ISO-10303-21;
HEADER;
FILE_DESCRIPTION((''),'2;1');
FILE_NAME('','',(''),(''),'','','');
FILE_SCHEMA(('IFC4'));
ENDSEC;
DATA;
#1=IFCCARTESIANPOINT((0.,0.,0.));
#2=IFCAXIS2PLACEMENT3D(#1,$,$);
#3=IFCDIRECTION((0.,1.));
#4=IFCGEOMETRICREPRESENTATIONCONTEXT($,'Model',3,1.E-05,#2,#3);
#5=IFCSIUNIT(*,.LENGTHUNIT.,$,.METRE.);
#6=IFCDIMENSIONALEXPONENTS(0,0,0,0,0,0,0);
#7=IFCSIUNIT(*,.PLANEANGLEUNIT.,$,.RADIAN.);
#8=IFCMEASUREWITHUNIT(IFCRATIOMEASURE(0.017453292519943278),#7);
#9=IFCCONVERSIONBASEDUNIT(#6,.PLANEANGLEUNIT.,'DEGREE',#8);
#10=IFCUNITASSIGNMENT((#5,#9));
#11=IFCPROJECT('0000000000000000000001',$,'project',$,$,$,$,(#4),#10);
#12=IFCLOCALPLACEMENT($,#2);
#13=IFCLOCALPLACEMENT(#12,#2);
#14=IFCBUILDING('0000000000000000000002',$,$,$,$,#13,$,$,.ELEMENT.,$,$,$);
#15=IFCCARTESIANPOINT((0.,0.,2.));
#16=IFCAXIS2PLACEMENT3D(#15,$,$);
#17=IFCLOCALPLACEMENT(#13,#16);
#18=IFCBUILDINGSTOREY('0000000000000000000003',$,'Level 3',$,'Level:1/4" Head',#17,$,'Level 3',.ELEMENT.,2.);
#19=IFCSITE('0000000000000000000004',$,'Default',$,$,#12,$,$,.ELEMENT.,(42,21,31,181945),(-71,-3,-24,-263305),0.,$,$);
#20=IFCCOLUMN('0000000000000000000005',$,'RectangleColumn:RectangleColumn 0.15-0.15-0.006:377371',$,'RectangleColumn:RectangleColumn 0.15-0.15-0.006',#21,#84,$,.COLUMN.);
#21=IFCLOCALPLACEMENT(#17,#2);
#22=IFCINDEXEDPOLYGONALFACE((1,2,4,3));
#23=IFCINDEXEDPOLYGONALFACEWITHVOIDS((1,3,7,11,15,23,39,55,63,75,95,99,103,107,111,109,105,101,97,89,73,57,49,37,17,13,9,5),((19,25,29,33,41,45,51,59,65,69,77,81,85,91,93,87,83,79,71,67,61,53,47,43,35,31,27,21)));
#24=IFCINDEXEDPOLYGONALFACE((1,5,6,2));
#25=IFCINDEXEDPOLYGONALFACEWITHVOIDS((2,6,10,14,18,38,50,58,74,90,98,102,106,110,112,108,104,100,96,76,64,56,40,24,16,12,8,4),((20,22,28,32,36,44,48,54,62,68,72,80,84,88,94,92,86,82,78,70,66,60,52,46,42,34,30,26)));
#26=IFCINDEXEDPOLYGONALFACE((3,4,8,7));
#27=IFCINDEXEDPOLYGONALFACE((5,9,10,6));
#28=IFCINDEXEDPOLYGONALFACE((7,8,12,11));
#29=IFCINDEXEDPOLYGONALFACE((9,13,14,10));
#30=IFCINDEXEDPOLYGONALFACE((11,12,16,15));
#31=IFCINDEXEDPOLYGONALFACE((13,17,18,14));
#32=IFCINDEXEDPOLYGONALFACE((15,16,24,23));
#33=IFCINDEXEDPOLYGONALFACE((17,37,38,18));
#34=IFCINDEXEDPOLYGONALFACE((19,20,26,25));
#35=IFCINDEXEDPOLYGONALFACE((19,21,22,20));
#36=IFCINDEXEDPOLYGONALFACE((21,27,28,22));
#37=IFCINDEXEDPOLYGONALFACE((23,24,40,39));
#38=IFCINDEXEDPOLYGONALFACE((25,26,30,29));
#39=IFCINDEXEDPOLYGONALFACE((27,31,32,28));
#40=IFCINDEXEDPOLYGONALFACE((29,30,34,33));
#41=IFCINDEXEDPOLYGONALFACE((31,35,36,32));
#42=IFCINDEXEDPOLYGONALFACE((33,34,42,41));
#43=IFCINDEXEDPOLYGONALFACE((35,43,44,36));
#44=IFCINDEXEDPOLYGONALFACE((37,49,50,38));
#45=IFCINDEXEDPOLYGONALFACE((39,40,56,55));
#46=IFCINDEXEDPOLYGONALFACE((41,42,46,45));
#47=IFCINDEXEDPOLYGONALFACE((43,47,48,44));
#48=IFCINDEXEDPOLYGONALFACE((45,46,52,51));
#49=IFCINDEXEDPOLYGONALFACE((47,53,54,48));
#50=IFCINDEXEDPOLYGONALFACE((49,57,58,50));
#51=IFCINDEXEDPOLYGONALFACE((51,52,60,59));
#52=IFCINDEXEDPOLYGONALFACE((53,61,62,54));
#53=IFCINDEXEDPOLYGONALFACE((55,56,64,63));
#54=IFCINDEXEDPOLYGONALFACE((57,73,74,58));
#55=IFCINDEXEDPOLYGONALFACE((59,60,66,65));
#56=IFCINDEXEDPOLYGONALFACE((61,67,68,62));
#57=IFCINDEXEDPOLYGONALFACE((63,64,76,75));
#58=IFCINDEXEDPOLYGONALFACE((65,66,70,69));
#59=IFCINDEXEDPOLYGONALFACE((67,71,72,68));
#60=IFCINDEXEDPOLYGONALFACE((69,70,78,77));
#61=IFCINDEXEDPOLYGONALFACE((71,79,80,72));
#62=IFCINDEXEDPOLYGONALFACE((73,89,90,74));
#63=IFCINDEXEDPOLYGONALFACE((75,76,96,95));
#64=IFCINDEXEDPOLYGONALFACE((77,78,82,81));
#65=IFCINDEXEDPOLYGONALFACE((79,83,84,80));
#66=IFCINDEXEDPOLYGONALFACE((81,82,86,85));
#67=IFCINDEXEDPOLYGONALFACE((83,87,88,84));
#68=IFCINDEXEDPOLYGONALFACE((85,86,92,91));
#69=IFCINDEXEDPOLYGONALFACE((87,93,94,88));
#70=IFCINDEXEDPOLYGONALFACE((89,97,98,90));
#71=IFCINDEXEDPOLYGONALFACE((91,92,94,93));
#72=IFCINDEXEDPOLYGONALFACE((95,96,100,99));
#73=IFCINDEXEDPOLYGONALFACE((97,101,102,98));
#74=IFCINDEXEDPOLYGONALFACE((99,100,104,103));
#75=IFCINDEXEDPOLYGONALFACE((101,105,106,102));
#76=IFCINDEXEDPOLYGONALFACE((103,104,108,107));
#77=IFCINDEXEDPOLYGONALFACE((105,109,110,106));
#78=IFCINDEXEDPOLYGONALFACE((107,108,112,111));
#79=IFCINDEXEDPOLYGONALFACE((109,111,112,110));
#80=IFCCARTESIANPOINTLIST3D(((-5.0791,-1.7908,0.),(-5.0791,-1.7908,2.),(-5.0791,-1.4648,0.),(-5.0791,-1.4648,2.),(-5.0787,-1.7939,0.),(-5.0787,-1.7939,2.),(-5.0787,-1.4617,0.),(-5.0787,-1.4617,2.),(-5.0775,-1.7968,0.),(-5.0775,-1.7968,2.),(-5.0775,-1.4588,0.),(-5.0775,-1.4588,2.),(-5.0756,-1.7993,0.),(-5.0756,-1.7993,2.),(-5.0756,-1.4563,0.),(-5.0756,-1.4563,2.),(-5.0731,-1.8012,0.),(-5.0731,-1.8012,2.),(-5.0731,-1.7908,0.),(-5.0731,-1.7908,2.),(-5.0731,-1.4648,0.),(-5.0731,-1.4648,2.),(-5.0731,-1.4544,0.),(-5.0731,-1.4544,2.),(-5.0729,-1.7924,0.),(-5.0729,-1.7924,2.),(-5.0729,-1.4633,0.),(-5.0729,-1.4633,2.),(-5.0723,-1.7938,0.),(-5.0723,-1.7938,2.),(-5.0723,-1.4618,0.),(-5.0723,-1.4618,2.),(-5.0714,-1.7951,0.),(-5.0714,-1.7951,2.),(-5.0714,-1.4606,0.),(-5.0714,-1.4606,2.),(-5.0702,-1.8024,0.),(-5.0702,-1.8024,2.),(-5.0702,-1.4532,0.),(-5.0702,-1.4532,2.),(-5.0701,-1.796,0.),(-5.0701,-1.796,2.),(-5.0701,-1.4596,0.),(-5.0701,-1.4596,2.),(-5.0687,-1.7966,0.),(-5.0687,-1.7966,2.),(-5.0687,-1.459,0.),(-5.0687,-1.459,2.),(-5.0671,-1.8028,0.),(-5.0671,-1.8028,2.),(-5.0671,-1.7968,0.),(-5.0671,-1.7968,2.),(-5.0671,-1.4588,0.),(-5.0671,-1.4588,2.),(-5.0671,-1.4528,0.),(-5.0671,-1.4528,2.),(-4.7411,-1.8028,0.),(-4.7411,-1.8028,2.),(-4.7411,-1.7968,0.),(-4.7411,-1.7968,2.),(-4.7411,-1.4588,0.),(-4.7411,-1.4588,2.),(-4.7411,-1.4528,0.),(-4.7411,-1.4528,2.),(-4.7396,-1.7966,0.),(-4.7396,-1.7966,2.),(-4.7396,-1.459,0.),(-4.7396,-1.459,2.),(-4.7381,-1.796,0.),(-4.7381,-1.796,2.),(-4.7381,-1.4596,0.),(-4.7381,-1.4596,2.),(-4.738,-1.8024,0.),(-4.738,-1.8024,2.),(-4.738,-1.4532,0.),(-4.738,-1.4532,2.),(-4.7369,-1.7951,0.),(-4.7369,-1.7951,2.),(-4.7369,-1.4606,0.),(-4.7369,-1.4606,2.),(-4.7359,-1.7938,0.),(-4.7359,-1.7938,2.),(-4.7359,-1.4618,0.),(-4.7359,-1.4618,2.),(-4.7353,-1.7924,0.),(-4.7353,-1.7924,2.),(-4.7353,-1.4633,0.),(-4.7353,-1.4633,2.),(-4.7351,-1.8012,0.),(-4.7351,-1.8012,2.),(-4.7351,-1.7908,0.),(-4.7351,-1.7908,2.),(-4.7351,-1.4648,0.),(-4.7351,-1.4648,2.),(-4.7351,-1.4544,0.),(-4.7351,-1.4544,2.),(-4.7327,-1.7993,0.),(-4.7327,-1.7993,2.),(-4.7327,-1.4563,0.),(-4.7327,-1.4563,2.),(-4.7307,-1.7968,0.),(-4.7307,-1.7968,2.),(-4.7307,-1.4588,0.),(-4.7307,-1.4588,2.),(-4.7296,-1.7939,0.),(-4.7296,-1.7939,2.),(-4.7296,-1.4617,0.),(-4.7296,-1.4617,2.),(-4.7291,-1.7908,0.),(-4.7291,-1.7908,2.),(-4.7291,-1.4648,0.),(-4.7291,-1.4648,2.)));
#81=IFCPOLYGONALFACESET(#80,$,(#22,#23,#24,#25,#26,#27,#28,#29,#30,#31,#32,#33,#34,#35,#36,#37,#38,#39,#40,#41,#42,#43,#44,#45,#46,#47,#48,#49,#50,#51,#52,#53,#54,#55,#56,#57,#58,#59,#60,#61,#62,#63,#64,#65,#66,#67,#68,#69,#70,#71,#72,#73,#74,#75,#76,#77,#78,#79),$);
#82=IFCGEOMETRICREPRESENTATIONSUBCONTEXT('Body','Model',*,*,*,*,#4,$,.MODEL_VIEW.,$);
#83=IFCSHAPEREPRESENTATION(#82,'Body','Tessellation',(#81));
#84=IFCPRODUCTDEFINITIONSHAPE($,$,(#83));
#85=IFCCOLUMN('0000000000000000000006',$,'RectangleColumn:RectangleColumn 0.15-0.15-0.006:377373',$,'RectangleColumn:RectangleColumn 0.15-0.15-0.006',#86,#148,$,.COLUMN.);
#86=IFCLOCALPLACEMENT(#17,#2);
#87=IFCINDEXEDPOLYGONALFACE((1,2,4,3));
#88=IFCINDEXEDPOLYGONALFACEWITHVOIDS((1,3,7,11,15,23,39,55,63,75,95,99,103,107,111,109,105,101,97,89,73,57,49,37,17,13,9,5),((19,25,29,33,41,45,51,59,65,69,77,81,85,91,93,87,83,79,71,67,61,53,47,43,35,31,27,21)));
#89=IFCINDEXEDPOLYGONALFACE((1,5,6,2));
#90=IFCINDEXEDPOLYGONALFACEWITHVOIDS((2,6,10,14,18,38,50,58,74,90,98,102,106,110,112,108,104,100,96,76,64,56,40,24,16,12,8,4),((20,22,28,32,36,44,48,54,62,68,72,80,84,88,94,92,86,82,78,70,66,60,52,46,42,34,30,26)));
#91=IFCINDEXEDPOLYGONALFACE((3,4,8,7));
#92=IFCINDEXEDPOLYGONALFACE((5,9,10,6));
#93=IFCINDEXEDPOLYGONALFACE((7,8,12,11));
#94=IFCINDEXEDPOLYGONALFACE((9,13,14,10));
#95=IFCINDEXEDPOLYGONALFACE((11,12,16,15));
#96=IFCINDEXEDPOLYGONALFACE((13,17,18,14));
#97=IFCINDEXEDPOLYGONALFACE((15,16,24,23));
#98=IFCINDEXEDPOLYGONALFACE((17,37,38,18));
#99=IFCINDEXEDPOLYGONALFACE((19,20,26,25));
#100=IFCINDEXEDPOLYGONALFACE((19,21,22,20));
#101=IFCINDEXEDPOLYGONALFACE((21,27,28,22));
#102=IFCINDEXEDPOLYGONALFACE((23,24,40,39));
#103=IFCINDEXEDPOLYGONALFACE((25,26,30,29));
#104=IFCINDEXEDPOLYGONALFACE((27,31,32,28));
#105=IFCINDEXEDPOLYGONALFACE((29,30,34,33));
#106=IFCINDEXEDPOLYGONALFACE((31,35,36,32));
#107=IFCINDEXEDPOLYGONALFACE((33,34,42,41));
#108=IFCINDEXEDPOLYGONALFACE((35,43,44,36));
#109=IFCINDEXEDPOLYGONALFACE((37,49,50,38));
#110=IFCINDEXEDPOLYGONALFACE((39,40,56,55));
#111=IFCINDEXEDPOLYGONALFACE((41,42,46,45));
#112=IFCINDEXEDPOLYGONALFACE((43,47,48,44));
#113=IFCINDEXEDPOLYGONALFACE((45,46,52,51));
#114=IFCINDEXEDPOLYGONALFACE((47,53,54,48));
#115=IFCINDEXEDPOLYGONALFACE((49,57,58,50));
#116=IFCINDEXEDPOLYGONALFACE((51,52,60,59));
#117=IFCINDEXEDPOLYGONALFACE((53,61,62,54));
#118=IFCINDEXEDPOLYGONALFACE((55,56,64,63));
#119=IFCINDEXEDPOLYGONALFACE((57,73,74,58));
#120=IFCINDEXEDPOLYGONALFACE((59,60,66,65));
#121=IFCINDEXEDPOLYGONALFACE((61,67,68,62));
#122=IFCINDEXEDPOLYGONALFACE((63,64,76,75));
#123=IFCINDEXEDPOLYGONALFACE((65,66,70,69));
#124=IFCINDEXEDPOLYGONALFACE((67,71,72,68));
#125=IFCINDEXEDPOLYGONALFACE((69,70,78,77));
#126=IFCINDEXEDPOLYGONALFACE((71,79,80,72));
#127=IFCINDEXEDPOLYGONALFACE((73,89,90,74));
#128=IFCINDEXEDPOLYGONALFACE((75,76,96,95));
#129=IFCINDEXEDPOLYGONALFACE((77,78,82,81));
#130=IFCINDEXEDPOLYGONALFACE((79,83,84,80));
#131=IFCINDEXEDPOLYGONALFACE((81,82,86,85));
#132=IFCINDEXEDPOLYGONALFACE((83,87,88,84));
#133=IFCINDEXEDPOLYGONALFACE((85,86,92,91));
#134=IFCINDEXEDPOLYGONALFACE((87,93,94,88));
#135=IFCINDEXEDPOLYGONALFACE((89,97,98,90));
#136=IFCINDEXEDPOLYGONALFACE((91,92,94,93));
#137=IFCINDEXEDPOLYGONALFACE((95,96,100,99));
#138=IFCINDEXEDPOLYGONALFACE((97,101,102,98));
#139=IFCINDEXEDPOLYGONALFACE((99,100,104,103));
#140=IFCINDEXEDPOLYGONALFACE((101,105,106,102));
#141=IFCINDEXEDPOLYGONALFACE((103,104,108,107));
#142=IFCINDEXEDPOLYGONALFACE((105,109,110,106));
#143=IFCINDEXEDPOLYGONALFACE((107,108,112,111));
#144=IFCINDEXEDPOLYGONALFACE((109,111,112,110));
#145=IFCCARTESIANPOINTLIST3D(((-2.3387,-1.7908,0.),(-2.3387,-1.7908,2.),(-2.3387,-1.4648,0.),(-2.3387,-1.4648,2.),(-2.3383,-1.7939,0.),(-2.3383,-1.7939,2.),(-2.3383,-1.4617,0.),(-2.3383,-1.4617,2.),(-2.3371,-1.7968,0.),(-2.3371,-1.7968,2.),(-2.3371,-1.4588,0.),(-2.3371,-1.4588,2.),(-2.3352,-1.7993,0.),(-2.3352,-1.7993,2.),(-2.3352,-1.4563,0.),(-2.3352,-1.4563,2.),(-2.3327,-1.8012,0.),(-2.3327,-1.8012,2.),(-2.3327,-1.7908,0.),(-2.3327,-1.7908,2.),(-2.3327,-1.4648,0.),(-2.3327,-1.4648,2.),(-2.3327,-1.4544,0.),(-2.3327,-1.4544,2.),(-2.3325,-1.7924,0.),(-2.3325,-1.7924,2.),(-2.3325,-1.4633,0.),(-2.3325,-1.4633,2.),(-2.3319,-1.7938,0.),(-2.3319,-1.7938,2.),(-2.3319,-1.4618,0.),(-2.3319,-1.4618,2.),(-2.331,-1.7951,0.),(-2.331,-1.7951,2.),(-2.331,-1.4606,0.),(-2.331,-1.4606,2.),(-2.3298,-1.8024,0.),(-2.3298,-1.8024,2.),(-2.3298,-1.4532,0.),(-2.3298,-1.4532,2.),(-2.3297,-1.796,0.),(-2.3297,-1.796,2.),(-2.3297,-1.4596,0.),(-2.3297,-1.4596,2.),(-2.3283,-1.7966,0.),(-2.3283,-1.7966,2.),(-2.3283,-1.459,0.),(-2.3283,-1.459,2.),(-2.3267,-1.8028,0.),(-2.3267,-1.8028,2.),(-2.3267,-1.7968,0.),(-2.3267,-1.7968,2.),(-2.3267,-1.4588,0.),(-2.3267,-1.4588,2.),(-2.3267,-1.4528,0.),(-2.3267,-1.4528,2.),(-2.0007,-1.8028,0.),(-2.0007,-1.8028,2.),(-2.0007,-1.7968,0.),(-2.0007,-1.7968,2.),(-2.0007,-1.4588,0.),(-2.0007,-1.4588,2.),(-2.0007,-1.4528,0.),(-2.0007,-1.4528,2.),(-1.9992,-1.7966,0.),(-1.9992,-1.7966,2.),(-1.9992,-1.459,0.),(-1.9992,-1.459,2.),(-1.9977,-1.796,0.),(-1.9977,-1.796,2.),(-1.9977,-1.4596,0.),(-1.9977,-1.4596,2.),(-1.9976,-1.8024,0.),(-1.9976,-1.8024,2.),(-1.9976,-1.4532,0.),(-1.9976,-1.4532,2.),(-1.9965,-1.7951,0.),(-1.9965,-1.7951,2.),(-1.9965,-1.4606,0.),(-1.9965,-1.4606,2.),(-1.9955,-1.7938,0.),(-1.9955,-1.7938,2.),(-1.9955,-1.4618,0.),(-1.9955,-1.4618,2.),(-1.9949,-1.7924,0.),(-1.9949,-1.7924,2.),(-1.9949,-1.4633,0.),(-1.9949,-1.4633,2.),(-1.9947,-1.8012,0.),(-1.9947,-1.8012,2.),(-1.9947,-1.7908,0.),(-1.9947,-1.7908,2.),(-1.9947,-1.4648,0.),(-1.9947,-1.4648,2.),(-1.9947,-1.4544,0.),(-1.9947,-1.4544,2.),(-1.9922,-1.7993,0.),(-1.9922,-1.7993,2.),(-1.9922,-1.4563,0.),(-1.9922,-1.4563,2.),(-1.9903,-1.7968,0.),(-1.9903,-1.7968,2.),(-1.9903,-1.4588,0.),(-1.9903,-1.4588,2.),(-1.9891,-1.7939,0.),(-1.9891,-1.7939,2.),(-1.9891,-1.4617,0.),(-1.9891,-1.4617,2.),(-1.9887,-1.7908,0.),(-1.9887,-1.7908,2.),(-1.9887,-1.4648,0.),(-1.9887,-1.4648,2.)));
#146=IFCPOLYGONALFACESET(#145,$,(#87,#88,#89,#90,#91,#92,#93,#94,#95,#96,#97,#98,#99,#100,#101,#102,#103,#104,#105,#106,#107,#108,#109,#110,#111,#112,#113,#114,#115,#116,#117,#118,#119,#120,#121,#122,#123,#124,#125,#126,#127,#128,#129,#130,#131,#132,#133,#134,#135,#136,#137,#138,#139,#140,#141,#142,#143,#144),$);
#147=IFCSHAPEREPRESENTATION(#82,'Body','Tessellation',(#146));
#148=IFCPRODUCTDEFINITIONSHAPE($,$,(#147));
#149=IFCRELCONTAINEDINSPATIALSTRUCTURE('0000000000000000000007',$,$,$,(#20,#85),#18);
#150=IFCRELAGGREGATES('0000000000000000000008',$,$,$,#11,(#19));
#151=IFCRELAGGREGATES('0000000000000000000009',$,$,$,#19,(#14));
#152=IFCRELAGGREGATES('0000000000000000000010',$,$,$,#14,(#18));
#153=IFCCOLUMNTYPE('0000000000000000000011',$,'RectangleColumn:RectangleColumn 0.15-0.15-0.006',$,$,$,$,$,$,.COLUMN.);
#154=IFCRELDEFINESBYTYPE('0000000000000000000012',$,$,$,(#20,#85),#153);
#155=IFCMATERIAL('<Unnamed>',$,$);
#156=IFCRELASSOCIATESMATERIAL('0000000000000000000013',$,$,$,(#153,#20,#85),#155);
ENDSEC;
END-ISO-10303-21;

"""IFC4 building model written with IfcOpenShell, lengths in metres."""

from ifc_helpers import new_model, entity, si_unit, converted_unit, direction, frame, origin, place, context, subcontext, project, spatial, line, arc, indexed_curve, outline, extrude, source, transform, mapped, material, type_object, type_shapes, element, save


model = new_model("IFC4")

# Units and contexts
model_context = context("Model", 3, precision=1e-05, world=origin(), true_north=direction((0.0, 1.0)))
body_context = subcontext(model_context, "Body", "Model", "MODEL_VIEW")
ifc_project = project(units=[si_unit("LENGTHUNIT", "METRE"), converted_unit("PLANEANGLEUNIT", "DEGREE", entity("IfcRatioMeasure", 0.017453292519943278), si_unit("PLANEANGLEUNIT", "RADIAN"), dimensions=[0, 0, 0, 0, 0, 0, 0])], contexts=[model_context])

# Site, building, storey
site_placement = place(None, origin())
site = spatial("IfcSite", under=ifc_project, at=site_placement, Name="Default", CompositionType="ELEMENT", RefLatitude=(42, 21, 31, 181945), RefLongitude=(-71, -3, -24, -263305), RefElevation=0.0)
building_placement = place(site_placement, origin())
building = spatial("IfcBuilding", under=site, at=building_placement, CompositionType="ELEMENT")
storey_placement = place(building_placement, frame((0.0, 0.0, 2.0)))
storey = spatial("IfcBuildingStorey", under=building, at=storey_placement, Name="Level 3", ObjectType="Level:1/4\" Head", LongName="Level 3", CompositionType="ELEMENT", Elevation=2.0)

# Columns
ifc_material_1 = material(Name="<Unnamed>")
column_type = type_object("IfcColumnType", Name="RectangleColumn:RectangleColumn 0.15-0.15-0.006", PredefinedType="COLUMN", material=ifc_material_1)
shared_shape = source(origin(), body_context, "Body", "SweptSolid", [
    extrude(outline(indexed_curve([(-0.163, -0.175), (0.163, -0.175), (0.1715, -0.1715), (0.175, -0.163), (0.175, 0.163), (0.1715, 0.1715), (0.163, 0.175), (-0.163, 0.175), (-0.1715, 0.1715), (-0.175, 0.163), (-0.175, -0.163), (-0.1715, -0.1715)], segments=[line(1, 2), arc(2, 3, 4), line(4, 5), arc(5, 6, 7), line(7, 8), arc(8, 9, 10), line(10, 11), arc(11, 12, 1)], self_intersect=False), holes=[indexed_curve([(-0.163, -0.169), (-0.1672, -0.1672), (-0.169, -0.163), (-0.169, 0.163), (-0.1672, 0.1672), (-0.163, 0.169), (0.163, 0.169), (0.1672, 0.1672), (0.169, 0.163), (0.169, -0.163), (0.1672, -0.1672), (0.163, -0.169)], segments=[arc(1, 2, 3), line(3, 4), arc(4, 5, 6), line(6, 7), arc(7, 8, 9), line(9, 10), arc(10, 11, 12), line(12, 1)], self_intersect=False)]), frame((0.0, 0.0, 2.0), z_axis=(0.0, 0.0, 1.0), x_axis=(-1.0, 0.0, 0.0)), (0.0, 0.0, 1.0), 2.0),
])
type_shapes(column_type, [shared_shape])
for number, where, name in (
    (1, (-4.9041, -1.6278, -2.0), "RectangleColumn:RectangleColumn 0.15-0.15-0.006:377371"),
    (2, (-2.1637, -1.6278, -2.0), "RectangleColumn:RectangleColumn 0.15-0.15-0.006:377373"),
):
    element("IfcColumn", number, at=place(storey_placement, frame(where)), inside=storey, type_object=column_type, material=ifc_material_1, Name=name, ObjectType="RectangleColumn:RectangleColumn 0.15-0.15-0.006", PredefinedType="COLUMN", context=body_context, shape_type="MappedRepresentation", body=[
        mapped(shared_shape, transform((0.0, 0.0, 0.0), scale=1.0)),
    ])

save(model, "model.ifc")
